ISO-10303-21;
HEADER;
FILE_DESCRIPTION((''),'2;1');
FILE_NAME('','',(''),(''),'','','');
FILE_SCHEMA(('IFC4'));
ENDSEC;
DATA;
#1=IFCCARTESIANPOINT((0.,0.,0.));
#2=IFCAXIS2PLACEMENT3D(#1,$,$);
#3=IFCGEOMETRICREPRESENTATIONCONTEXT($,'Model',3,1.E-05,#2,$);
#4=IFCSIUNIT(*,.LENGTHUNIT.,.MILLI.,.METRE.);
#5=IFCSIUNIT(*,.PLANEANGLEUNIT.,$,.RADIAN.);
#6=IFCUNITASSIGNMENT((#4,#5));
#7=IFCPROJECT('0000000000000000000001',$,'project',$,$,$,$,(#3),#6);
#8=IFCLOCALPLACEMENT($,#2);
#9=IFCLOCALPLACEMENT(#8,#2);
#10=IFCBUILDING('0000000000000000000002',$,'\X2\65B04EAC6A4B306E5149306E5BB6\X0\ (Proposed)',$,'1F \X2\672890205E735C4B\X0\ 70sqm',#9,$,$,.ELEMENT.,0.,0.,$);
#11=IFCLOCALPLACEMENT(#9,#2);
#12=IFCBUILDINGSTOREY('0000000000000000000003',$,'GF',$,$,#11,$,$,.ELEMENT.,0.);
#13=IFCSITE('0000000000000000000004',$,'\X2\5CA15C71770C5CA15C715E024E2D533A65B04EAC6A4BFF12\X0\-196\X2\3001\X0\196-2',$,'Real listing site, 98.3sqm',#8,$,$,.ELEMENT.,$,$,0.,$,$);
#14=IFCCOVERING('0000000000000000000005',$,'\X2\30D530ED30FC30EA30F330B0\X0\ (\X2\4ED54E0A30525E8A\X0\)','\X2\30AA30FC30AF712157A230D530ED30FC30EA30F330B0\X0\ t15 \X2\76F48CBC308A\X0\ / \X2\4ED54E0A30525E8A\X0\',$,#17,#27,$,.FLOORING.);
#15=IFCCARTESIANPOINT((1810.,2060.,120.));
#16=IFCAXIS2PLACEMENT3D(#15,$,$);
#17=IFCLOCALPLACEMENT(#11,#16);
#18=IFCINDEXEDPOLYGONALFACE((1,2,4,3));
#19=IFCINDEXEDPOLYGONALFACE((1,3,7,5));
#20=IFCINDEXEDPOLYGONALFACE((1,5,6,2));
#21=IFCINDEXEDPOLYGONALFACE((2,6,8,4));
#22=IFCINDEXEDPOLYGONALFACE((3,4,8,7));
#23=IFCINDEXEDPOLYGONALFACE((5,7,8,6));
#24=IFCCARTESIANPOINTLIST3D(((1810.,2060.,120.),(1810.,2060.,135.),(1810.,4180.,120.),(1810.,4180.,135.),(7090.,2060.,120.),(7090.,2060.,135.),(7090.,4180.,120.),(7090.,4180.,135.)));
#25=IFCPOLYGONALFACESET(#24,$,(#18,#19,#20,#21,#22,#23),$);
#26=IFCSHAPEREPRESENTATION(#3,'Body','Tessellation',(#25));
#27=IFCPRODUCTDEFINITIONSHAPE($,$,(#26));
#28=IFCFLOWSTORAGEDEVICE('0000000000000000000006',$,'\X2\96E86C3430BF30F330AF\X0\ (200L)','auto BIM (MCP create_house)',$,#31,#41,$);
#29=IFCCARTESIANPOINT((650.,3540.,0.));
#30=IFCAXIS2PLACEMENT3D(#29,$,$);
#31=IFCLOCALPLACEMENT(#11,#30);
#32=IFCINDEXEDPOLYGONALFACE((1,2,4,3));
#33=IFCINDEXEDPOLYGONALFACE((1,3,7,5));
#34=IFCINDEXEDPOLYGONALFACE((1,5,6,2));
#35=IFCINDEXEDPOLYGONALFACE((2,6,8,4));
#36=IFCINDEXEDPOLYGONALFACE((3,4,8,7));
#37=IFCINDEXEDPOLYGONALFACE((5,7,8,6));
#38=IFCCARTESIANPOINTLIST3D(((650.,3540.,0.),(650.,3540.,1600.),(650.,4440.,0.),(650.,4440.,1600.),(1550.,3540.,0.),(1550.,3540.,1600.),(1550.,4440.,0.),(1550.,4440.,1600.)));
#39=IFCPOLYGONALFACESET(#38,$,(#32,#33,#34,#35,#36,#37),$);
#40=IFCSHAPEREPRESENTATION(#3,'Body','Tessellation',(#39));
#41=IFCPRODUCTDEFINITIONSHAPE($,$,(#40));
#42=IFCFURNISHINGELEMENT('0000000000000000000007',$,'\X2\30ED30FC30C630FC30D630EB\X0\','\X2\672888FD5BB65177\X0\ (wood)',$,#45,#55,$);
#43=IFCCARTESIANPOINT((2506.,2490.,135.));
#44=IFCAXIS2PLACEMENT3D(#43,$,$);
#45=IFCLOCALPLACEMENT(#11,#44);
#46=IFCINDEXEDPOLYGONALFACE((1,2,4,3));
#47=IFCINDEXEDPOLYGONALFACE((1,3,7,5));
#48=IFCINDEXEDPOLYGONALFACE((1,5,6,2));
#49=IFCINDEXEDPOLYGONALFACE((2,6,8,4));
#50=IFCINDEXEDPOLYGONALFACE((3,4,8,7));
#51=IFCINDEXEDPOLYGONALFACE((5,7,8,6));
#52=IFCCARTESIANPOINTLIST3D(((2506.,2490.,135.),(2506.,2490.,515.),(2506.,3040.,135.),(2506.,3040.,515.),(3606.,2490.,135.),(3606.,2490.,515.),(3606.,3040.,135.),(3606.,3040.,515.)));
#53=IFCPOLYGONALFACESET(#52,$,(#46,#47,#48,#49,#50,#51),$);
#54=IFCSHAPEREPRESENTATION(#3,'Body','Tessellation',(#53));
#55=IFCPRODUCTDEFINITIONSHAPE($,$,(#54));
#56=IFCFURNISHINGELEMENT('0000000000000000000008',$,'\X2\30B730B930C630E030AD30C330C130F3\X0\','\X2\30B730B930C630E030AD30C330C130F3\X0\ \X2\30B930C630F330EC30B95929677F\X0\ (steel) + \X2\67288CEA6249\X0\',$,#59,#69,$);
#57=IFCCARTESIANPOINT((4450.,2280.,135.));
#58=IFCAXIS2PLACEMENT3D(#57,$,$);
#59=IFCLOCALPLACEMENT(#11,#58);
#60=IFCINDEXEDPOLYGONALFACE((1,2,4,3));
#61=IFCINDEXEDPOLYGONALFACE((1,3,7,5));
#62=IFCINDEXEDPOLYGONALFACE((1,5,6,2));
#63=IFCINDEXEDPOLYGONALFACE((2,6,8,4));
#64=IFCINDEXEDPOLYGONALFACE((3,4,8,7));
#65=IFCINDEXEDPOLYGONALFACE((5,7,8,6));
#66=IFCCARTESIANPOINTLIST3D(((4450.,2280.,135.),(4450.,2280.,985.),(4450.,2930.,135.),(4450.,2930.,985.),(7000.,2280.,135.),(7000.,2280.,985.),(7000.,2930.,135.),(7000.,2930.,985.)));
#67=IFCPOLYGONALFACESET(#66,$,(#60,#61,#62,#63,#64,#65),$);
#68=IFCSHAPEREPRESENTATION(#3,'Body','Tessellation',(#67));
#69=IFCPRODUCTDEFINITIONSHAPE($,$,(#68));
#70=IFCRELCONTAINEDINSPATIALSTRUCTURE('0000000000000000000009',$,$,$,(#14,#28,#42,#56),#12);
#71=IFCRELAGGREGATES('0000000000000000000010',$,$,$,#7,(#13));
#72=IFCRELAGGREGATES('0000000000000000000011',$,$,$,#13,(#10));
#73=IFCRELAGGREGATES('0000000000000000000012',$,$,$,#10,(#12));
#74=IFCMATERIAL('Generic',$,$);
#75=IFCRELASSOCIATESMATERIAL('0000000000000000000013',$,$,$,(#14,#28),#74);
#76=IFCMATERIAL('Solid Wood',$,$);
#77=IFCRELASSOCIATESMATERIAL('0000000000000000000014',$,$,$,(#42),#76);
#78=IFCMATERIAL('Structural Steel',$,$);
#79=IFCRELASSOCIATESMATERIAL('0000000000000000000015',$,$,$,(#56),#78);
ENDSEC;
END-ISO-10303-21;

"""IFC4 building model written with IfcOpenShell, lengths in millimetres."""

from ifc_helpers import new_model, si_unit, frame, frame_2d, origin, place, context, project, spatial, rectangle, extrude, material, element, save


model = new_model("IFC4")

# Units and contexts
model_context = context("Model", 3, precision=1e-05, world=origin())
ifc_project = project(units=[si_unit("LENGTHUNIT", "METRE", prefix="MILLI"), si_unit("PLANEANGLEUNIT", "RADIAN")], contexts=[model_context])

# Site, building, storey
site_placement = place(None, origin())
site = spatial("IfcSite", under=ifc_project, at=site_placement, Name="岡山県岡山市中区新京橋２-196、196-2", ObjectType="Real listing site, 98.3sqm", CompositionType="ELEMENT", RefElevation=0.0)
building_placement = place(site_placement, origin())
building = spatial("IfcBuilding", under=site, at=building_placement, Name="新京橋の光の家 (Proposed)", ObjectType="1F 木造平屋 70sqm", CompositionType="ELEMENT", ElevationOfRefHeight=0.0, ElevationOfTerrain=0.0)
storey_placement = place(building_placement, origin())
storey = spatial("IfcBuildingStorey", under=building, at=storey_placement, Name="GF", CompositionType="ELEMENT", Elevation=0.0)

# Shared definitions
ifc_material_1 = material(Name="Solid Wood")

# Covering
ifc_material_2 = material(Name="Generic")
covering_placement = place(storey_placement, frame((1810.0, 2060.0, 120.0)))
element("IfcCovering", 1, at=covering_placement, inside=storey, material=ifc_material_2, Name="フローリング (仕上げ床)", Description="オーク無垢フローリング t15 直貼り / 仕上げ床", PredefinedType="FLOORING", context=model_context, shape_type="SweptSolid", body=[
    extrude(rectangle(XDim=5280.0, YDim=2120.0, at=frame_2d((2640.0, 1060.0))), frame((1810.0, 2060.0, 120.0)), (0.0, 0.0, 1.0), 15.0),
])

# Flow storage device
flow_storage_device_placement = place(storey_placement, frame((650.0, 3540.0, 0.0)))
element("IfcFlowStorageDevice", 2, at=flow_storage_device_placement, inside=storey, material=ifc_material_2, Name="雨水タンク (200L)", Description="auto BIM (MCP create_house)", context=model_context, shape_type="SweptSolid", body=[
    extrude(rectangle(XDim=900.0, YDim=900.0, at=frame_2d((450.0, 450.0))), frame((650.0, 3540.0, 0.0)), (0.0, 0.0, 1.0), 1600.0),
])

# Furnishing elements
furnishing_1_placement = place(storey_placement, frame((2506.0, 2490.0, 135.0)))
element("IfcFurnishingElement", 3, at=furnishing_1_placement, inside=storey, material=ifc_material_1, Name="ローテーブル", Description="木製家具 (wood)", context=model_context, shape_type="SweptSolid", body=[
    extrude(rectangle(XDim=1100.0, YDim=550.0, at=frame_2d((550.0, 275.0))), frame((2506.0, 2490.0, 135.0)), (0.0, 0.0, 1.0), 380.0),
])
ifc_material_3 = material(Name="Structural Steel")
furnishing_2_placement = place(storey_placement, frame((4450.0, 2280.0, 135.0)))
element("IfcFurnishingElement", 4, at=furnishing_2_placement, inside=storey, material=ifc_material_3, Name="システムキッチン", Description="システムキッチン ステンレス天板 (steel) + 木質扉", context=model_context, shape_type="SweptSolid", body=[
    extrude(rectangle(XDim=2550.0, YDim=650.0, at=frame_2d((1275.0, 325.0))), frame((4450.0, 2280.0, 135.0)), (0.0, 0.0, 1.0), 850.0),
])

save(model, "model.ifc")
